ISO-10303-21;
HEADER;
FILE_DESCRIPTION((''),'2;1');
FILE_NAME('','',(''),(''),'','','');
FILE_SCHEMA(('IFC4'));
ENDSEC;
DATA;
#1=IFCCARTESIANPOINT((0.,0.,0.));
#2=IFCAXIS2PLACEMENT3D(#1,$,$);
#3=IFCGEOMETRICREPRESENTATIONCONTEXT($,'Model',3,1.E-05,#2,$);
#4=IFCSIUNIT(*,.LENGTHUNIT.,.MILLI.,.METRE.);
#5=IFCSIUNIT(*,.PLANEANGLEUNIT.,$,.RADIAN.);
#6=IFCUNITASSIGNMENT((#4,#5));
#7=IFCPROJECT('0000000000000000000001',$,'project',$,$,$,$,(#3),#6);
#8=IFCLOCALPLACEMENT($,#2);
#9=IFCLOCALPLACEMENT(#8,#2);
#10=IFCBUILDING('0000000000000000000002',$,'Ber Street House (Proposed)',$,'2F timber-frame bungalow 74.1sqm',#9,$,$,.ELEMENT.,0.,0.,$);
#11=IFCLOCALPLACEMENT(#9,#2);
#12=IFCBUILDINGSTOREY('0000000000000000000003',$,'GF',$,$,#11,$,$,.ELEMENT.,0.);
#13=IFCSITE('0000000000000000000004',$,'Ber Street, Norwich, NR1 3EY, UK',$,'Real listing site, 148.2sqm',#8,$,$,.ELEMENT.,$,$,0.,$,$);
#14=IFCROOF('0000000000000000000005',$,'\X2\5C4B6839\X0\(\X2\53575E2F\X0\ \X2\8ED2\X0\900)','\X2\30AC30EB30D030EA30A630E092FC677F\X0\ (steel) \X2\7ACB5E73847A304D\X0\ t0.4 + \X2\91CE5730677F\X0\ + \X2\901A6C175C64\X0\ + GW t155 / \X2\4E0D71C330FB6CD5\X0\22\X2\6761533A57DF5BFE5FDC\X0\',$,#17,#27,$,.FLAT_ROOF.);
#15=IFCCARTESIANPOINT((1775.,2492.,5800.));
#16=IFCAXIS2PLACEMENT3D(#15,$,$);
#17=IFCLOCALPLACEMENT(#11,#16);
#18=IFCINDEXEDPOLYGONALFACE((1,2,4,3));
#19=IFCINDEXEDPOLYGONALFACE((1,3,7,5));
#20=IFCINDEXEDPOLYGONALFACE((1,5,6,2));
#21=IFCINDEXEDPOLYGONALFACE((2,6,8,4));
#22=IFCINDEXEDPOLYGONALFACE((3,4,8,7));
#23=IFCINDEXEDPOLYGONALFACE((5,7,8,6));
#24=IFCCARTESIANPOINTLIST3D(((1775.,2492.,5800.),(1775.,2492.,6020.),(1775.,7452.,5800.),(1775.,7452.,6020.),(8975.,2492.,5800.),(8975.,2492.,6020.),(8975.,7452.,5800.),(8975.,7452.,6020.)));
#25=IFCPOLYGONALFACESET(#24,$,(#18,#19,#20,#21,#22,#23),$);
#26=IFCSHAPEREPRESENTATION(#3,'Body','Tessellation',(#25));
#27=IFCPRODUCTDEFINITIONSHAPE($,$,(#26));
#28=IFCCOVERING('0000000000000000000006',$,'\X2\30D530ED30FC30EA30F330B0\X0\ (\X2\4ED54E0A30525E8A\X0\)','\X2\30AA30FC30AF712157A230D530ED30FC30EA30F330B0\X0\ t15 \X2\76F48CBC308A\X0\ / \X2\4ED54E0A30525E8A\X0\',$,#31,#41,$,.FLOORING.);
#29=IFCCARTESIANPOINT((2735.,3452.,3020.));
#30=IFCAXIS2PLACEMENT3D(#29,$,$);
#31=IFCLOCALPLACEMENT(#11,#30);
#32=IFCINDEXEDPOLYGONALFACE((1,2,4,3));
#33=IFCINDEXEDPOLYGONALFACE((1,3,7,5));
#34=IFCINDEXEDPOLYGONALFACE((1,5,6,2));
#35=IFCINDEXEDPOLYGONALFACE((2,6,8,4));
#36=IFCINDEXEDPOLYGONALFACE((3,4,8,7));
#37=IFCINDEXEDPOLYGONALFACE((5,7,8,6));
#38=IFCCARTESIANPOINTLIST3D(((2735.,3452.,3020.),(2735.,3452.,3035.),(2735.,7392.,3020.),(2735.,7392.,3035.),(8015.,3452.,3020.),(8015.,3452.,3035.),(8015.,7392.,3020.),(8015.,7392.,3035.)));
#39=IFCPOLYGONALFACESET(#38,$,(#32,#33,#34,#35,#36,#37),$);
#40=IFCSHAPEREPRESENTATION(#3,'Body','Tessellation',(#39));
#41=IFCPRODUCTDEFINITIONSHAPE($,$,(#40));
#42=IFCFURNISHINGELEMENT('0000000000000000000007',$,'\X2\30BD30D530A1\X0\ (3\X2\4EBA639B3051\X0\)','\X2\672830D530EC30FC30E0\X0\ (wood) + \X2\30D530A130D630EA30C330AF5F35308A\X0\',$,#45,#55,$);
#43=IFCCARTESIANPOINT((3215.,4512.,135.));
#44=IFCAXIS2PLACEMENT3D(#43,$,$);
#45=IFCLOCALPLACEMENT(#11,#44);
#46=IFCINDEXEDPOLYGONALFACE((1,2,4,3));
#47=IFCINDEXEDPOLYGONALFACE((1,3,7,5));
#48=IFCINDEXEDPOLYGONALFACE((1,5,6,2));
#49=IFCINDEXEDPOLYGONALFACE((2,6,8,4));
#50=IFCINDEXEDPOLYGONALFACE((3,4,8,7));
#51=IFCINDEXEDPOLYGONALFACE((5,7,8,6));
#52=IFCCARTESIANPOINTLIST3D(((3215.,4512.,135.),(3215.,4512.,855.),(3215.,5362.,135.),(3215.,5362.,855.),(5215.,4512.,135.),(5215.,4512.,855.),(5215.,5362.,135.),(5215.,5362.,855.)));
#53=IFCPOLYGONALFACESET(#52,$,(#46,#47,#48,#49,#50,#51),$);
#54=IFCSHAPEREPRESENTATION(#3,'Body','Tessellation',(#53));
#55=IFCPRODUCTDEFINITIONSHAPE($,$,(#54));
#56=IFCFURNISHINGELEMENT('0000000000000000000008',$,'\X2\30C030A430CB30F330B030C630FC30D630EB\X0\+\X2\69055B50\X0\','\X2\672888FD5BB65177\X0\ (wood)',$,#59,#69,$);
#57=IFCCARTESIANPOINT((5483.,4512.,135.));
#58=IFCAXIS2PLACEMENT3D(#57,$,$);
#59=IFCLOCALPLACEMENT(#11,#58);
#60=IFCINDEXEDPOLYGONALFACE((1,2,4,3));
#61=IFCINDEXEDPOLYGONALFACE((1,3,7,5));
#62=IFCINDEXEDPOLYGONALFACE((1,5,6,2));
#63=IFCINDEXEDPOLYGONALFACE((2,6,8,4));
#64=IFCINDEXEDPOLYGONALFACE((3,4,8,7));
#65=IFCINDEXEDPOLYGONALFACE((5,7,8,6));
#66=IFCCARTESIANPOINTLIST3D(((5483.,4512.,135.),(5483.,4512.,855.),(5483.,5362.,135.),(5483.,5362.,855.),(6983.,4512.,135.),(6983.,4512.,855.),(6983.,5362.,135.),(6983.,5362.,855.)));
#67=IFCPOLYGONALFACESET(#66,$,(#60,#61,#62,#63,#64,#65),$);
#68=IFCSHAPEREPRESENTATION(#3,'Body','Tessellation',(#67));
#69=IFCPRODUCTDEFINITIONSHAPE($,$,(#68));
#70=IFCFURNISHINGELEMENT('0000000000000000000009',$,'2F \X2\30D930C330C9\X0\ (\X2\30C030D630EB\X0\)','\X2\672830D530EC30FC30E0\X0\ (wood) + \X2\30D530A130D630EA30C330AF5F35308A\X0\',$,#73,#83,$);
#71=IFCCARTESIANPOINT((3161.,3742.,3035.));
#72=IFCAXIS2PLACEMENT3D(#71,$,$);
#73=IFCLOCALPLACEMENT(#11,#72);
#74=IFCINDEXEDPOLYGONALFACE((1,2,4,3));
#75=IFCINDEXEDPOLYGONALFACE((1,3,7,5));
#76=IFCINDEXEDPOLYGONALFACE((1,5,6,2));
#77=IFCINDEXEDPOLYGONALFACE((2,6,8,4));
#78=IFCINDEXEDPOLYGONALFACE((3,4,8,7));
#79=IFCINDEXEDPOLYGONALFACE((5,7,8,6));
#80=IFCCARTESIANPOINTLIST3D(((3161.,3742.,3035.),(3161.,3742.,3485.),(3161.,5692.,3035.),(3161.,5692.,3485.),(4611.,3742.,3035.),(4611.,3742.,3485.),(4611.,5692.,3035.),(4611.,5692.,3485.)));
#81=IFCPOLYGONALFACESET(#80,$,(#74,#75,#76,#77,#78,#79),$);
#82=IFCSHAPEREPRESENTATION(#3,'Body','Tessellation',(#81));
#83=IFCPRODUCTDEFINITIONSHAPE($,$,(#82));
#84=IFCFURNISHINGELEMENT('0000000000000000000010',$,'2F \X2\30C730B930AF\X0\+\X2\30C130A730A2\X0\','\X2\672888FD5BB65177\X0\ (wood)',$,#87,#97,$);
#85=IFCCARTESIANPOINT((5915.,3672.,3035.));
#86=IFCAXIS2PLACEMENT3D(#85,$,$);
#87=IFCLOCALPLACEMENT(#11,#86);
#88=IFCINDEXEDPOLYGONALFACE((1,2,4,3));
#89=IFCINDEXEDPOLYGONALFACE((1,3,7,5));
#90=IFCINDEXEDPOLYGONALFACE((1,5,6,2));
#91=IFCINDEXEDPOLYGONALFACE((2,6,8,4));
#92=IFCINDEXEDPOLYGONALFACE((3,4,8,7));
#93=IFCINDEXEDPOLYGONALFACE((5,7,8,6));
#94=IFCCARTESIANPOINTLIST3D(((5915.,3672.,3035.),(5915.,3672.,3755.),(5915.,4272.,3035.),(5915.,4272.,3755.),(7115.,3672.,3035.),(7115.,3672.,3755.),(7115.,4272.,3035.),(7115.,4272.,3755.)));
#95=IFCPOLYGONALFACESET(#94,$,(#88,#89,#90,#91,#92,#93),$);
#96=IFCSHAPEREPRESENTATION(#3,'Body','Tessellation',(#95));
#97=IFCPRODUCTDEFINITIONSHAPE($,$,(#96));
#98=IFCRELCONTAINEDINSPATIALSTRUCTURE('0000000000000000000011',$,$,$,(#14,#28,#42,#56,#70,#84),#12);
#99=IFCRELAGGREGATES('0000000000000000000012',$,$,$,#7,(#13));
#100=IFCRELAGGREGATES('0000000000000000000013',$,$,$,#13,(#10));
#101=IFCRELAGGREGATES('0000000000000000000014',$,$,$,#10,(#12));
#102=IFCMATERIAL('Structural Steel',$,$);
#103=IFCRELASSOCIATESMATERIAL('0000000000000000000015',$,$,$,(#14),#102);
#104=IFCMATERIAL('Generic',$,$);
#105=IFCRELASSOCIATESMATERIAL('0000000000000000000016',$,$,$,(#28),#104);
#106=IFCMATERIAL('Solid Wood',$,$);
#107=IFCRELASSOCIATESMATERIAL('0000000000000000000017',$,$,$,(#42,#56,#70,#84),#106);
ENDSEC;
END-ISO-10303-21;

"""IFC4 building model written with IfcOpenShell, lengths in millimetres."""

from ifc_helpers import new_model, si_unit, frame, frame_2d, origin, place, context, project, spatial, rectangle, extrude, material, element, save


model = new_model("IFC4")

# Units and contexts
model_context = context("Model", 3, precision=1e-05, world=origin())
ifc_project = project(units=[si_unit("LENGTHUNIT", "METRE", prefix="MILLI"), si_unit("PLANEANGLEUNIT", "RADIAN")], contexts=[model_context])

# Site, building, storey
site_placement = place(None, origin())
site = spatial("IfcSite", under=ifc_project, at=site_placement, Name="Ber Street, Norwich, NR1 3EY, UK", ObjectType="Real listing site, 148.2sqm", CompositionType="ELEMENT", RefElevation=0.0)
building_placement = place(site_placement, origin())
building = spatial("IfcBuilding", under=site, at=building_placement, Name="Ber Street House (Proposed)", ObjectType="2F timber-frame bungalow 74.1sqm", CompositionType="ELEMENT", ElevationOfRefHeight=0.0, ElevationOfTerrain=0.0)
storey_placement = place(building_placement, origin())
storey = spatial("IfcBuildingStorey", under=building, at=storey_placement, Name="GF", CompositionType="ELEMENT", Elevation=0.0)

# Shared definitions
ifc_material_1 = material(Name="Solid Wood")

# Roof
ifc_material_2 = material(Name="Structural Steel")
for number, where, name in (
    (1, (1775.0, 2492.0, 5800.0), "屋根(南帯 軒900)"),
):
    element("IfcRoof", number, at=place(storey_placement, frame(where)), inside=storey, material=ifc_material_2, Name=name, Description="ガルバリウム鋼板 (steel) 立平葺き t0.4 + 野地板 + 通気層 + GW t155 / 不燃・法22条区域対応", PredefinedType="FLAT_ROOF", context=model_context, shape_type="SweptSolid", body=[
        extrude(rectangle(XDim=7200.0, YDim=4960.0, at=frame_2d((3600.0, 2480.0))), frame((1775.0, 2492.0, 5800.0)), (0.0, 0.0, 1.0), 220.0),
    ])

# Covering
ifc_material_3 = material(Name="Generic")
covering_placement = place(storey_placement, frame((2735.0, 3452.0, 3020.0)))
element("IfcCovering", 2, at=covering_placement, inside=storey, material=ifc_material_3, Name="フローリング (仕上げ床)", Description="オーク無垢フローリング t15 直貼り / 仕上げ床", PredefinedType="FLOORING", context=model_context, shape_type="SweptSolid", body=[
    extrude(rectangle(XDim=5280.0, YDim=3940.0, at=frame_2d((2640.0, 1970.0))), frame((2735.0, 3452.0, 3020.0)), (0.0, 0.0, 1.0), 15.0),
])

# Furnishing elements
furnishing_1_placement = place(storey_placement, frame((3215.0, 4512.0, 135.0)))
element("IfcFurnishingElement", 3, at=furnishing_1_placement, inside=storey, material=ifc_material_1, Name="ソファ (3人掛け)", Description="木フレーム (wood) + ファブリック張り", context=model_context, shape_type="SweptSolid", body=[
    extrude(rectangle(XDim=2000.0, YDim=850.0, at=frame_2d((1000.0, 425.0))), frame((3215.0, 4512.0, 135.0)), (0.0, 0.0, 1.0), 720.0),
])
furnishing_2_placement = place(storey_placement, frame((5483.0, 4512.0, 135.0)))
element("IfcFurnishingElement", 4, at=furnishing_2_placement, inside=storey, material=ifc_material_1, Name="ダイニングテーブル+椅子", Description="木製家具 (wood)", context=model_context, shape_type="SweptSolid", body=[
    extrude(rectangle(XDim=1500.0, YDim=850.0, at=frame_2d((750.0, 425.0))), frame((5483.0, 4512.0, 135.0)), (0.0, 0.0, 1.0), 720.0),
])
furnishing_3_placement = place(storey_placement, frame((3161.0, 3742.0, 3035.0)))
element("IfcFurnishingElement", 5, at=furnishing_3_placement, inside=storey, material=ifc_material_1, Name="2F ベッド (ダブル)", Description="木フレーム (wood) + ファブリック張り", context=model_context, shape_type="SweptSolid", body=[
    extrude(rectangle(XDim=1450.0, YDim=1950.0, at=frame_2d((725.0, 975.0))), frame((3161.0, 3742.0, 3035.0)), (0.0, 0.0, 1.0), 450.0),
])
furnishing_4_placement = place(storey_placement, frame((5915.0, 3672.0, 3035.0)))
element("IfcFurnishingElement", 6, at=furnishing_4_placement, inside=storey, material=ifc_material_1, Name="2F デスク+チェア", Description="木製家具 (wood)", context=model_context, shape_type="SweptSolid", body=[
    extrude(rectangle(XDim=1200.0, YDim=600.0, at=frame_2d((600.0, 300.0))), frame((5915.0, 3672.0, 3035.0)), (0.0, 0.0, 1.0), 720.0),
])

save(model, "model.ifc")
